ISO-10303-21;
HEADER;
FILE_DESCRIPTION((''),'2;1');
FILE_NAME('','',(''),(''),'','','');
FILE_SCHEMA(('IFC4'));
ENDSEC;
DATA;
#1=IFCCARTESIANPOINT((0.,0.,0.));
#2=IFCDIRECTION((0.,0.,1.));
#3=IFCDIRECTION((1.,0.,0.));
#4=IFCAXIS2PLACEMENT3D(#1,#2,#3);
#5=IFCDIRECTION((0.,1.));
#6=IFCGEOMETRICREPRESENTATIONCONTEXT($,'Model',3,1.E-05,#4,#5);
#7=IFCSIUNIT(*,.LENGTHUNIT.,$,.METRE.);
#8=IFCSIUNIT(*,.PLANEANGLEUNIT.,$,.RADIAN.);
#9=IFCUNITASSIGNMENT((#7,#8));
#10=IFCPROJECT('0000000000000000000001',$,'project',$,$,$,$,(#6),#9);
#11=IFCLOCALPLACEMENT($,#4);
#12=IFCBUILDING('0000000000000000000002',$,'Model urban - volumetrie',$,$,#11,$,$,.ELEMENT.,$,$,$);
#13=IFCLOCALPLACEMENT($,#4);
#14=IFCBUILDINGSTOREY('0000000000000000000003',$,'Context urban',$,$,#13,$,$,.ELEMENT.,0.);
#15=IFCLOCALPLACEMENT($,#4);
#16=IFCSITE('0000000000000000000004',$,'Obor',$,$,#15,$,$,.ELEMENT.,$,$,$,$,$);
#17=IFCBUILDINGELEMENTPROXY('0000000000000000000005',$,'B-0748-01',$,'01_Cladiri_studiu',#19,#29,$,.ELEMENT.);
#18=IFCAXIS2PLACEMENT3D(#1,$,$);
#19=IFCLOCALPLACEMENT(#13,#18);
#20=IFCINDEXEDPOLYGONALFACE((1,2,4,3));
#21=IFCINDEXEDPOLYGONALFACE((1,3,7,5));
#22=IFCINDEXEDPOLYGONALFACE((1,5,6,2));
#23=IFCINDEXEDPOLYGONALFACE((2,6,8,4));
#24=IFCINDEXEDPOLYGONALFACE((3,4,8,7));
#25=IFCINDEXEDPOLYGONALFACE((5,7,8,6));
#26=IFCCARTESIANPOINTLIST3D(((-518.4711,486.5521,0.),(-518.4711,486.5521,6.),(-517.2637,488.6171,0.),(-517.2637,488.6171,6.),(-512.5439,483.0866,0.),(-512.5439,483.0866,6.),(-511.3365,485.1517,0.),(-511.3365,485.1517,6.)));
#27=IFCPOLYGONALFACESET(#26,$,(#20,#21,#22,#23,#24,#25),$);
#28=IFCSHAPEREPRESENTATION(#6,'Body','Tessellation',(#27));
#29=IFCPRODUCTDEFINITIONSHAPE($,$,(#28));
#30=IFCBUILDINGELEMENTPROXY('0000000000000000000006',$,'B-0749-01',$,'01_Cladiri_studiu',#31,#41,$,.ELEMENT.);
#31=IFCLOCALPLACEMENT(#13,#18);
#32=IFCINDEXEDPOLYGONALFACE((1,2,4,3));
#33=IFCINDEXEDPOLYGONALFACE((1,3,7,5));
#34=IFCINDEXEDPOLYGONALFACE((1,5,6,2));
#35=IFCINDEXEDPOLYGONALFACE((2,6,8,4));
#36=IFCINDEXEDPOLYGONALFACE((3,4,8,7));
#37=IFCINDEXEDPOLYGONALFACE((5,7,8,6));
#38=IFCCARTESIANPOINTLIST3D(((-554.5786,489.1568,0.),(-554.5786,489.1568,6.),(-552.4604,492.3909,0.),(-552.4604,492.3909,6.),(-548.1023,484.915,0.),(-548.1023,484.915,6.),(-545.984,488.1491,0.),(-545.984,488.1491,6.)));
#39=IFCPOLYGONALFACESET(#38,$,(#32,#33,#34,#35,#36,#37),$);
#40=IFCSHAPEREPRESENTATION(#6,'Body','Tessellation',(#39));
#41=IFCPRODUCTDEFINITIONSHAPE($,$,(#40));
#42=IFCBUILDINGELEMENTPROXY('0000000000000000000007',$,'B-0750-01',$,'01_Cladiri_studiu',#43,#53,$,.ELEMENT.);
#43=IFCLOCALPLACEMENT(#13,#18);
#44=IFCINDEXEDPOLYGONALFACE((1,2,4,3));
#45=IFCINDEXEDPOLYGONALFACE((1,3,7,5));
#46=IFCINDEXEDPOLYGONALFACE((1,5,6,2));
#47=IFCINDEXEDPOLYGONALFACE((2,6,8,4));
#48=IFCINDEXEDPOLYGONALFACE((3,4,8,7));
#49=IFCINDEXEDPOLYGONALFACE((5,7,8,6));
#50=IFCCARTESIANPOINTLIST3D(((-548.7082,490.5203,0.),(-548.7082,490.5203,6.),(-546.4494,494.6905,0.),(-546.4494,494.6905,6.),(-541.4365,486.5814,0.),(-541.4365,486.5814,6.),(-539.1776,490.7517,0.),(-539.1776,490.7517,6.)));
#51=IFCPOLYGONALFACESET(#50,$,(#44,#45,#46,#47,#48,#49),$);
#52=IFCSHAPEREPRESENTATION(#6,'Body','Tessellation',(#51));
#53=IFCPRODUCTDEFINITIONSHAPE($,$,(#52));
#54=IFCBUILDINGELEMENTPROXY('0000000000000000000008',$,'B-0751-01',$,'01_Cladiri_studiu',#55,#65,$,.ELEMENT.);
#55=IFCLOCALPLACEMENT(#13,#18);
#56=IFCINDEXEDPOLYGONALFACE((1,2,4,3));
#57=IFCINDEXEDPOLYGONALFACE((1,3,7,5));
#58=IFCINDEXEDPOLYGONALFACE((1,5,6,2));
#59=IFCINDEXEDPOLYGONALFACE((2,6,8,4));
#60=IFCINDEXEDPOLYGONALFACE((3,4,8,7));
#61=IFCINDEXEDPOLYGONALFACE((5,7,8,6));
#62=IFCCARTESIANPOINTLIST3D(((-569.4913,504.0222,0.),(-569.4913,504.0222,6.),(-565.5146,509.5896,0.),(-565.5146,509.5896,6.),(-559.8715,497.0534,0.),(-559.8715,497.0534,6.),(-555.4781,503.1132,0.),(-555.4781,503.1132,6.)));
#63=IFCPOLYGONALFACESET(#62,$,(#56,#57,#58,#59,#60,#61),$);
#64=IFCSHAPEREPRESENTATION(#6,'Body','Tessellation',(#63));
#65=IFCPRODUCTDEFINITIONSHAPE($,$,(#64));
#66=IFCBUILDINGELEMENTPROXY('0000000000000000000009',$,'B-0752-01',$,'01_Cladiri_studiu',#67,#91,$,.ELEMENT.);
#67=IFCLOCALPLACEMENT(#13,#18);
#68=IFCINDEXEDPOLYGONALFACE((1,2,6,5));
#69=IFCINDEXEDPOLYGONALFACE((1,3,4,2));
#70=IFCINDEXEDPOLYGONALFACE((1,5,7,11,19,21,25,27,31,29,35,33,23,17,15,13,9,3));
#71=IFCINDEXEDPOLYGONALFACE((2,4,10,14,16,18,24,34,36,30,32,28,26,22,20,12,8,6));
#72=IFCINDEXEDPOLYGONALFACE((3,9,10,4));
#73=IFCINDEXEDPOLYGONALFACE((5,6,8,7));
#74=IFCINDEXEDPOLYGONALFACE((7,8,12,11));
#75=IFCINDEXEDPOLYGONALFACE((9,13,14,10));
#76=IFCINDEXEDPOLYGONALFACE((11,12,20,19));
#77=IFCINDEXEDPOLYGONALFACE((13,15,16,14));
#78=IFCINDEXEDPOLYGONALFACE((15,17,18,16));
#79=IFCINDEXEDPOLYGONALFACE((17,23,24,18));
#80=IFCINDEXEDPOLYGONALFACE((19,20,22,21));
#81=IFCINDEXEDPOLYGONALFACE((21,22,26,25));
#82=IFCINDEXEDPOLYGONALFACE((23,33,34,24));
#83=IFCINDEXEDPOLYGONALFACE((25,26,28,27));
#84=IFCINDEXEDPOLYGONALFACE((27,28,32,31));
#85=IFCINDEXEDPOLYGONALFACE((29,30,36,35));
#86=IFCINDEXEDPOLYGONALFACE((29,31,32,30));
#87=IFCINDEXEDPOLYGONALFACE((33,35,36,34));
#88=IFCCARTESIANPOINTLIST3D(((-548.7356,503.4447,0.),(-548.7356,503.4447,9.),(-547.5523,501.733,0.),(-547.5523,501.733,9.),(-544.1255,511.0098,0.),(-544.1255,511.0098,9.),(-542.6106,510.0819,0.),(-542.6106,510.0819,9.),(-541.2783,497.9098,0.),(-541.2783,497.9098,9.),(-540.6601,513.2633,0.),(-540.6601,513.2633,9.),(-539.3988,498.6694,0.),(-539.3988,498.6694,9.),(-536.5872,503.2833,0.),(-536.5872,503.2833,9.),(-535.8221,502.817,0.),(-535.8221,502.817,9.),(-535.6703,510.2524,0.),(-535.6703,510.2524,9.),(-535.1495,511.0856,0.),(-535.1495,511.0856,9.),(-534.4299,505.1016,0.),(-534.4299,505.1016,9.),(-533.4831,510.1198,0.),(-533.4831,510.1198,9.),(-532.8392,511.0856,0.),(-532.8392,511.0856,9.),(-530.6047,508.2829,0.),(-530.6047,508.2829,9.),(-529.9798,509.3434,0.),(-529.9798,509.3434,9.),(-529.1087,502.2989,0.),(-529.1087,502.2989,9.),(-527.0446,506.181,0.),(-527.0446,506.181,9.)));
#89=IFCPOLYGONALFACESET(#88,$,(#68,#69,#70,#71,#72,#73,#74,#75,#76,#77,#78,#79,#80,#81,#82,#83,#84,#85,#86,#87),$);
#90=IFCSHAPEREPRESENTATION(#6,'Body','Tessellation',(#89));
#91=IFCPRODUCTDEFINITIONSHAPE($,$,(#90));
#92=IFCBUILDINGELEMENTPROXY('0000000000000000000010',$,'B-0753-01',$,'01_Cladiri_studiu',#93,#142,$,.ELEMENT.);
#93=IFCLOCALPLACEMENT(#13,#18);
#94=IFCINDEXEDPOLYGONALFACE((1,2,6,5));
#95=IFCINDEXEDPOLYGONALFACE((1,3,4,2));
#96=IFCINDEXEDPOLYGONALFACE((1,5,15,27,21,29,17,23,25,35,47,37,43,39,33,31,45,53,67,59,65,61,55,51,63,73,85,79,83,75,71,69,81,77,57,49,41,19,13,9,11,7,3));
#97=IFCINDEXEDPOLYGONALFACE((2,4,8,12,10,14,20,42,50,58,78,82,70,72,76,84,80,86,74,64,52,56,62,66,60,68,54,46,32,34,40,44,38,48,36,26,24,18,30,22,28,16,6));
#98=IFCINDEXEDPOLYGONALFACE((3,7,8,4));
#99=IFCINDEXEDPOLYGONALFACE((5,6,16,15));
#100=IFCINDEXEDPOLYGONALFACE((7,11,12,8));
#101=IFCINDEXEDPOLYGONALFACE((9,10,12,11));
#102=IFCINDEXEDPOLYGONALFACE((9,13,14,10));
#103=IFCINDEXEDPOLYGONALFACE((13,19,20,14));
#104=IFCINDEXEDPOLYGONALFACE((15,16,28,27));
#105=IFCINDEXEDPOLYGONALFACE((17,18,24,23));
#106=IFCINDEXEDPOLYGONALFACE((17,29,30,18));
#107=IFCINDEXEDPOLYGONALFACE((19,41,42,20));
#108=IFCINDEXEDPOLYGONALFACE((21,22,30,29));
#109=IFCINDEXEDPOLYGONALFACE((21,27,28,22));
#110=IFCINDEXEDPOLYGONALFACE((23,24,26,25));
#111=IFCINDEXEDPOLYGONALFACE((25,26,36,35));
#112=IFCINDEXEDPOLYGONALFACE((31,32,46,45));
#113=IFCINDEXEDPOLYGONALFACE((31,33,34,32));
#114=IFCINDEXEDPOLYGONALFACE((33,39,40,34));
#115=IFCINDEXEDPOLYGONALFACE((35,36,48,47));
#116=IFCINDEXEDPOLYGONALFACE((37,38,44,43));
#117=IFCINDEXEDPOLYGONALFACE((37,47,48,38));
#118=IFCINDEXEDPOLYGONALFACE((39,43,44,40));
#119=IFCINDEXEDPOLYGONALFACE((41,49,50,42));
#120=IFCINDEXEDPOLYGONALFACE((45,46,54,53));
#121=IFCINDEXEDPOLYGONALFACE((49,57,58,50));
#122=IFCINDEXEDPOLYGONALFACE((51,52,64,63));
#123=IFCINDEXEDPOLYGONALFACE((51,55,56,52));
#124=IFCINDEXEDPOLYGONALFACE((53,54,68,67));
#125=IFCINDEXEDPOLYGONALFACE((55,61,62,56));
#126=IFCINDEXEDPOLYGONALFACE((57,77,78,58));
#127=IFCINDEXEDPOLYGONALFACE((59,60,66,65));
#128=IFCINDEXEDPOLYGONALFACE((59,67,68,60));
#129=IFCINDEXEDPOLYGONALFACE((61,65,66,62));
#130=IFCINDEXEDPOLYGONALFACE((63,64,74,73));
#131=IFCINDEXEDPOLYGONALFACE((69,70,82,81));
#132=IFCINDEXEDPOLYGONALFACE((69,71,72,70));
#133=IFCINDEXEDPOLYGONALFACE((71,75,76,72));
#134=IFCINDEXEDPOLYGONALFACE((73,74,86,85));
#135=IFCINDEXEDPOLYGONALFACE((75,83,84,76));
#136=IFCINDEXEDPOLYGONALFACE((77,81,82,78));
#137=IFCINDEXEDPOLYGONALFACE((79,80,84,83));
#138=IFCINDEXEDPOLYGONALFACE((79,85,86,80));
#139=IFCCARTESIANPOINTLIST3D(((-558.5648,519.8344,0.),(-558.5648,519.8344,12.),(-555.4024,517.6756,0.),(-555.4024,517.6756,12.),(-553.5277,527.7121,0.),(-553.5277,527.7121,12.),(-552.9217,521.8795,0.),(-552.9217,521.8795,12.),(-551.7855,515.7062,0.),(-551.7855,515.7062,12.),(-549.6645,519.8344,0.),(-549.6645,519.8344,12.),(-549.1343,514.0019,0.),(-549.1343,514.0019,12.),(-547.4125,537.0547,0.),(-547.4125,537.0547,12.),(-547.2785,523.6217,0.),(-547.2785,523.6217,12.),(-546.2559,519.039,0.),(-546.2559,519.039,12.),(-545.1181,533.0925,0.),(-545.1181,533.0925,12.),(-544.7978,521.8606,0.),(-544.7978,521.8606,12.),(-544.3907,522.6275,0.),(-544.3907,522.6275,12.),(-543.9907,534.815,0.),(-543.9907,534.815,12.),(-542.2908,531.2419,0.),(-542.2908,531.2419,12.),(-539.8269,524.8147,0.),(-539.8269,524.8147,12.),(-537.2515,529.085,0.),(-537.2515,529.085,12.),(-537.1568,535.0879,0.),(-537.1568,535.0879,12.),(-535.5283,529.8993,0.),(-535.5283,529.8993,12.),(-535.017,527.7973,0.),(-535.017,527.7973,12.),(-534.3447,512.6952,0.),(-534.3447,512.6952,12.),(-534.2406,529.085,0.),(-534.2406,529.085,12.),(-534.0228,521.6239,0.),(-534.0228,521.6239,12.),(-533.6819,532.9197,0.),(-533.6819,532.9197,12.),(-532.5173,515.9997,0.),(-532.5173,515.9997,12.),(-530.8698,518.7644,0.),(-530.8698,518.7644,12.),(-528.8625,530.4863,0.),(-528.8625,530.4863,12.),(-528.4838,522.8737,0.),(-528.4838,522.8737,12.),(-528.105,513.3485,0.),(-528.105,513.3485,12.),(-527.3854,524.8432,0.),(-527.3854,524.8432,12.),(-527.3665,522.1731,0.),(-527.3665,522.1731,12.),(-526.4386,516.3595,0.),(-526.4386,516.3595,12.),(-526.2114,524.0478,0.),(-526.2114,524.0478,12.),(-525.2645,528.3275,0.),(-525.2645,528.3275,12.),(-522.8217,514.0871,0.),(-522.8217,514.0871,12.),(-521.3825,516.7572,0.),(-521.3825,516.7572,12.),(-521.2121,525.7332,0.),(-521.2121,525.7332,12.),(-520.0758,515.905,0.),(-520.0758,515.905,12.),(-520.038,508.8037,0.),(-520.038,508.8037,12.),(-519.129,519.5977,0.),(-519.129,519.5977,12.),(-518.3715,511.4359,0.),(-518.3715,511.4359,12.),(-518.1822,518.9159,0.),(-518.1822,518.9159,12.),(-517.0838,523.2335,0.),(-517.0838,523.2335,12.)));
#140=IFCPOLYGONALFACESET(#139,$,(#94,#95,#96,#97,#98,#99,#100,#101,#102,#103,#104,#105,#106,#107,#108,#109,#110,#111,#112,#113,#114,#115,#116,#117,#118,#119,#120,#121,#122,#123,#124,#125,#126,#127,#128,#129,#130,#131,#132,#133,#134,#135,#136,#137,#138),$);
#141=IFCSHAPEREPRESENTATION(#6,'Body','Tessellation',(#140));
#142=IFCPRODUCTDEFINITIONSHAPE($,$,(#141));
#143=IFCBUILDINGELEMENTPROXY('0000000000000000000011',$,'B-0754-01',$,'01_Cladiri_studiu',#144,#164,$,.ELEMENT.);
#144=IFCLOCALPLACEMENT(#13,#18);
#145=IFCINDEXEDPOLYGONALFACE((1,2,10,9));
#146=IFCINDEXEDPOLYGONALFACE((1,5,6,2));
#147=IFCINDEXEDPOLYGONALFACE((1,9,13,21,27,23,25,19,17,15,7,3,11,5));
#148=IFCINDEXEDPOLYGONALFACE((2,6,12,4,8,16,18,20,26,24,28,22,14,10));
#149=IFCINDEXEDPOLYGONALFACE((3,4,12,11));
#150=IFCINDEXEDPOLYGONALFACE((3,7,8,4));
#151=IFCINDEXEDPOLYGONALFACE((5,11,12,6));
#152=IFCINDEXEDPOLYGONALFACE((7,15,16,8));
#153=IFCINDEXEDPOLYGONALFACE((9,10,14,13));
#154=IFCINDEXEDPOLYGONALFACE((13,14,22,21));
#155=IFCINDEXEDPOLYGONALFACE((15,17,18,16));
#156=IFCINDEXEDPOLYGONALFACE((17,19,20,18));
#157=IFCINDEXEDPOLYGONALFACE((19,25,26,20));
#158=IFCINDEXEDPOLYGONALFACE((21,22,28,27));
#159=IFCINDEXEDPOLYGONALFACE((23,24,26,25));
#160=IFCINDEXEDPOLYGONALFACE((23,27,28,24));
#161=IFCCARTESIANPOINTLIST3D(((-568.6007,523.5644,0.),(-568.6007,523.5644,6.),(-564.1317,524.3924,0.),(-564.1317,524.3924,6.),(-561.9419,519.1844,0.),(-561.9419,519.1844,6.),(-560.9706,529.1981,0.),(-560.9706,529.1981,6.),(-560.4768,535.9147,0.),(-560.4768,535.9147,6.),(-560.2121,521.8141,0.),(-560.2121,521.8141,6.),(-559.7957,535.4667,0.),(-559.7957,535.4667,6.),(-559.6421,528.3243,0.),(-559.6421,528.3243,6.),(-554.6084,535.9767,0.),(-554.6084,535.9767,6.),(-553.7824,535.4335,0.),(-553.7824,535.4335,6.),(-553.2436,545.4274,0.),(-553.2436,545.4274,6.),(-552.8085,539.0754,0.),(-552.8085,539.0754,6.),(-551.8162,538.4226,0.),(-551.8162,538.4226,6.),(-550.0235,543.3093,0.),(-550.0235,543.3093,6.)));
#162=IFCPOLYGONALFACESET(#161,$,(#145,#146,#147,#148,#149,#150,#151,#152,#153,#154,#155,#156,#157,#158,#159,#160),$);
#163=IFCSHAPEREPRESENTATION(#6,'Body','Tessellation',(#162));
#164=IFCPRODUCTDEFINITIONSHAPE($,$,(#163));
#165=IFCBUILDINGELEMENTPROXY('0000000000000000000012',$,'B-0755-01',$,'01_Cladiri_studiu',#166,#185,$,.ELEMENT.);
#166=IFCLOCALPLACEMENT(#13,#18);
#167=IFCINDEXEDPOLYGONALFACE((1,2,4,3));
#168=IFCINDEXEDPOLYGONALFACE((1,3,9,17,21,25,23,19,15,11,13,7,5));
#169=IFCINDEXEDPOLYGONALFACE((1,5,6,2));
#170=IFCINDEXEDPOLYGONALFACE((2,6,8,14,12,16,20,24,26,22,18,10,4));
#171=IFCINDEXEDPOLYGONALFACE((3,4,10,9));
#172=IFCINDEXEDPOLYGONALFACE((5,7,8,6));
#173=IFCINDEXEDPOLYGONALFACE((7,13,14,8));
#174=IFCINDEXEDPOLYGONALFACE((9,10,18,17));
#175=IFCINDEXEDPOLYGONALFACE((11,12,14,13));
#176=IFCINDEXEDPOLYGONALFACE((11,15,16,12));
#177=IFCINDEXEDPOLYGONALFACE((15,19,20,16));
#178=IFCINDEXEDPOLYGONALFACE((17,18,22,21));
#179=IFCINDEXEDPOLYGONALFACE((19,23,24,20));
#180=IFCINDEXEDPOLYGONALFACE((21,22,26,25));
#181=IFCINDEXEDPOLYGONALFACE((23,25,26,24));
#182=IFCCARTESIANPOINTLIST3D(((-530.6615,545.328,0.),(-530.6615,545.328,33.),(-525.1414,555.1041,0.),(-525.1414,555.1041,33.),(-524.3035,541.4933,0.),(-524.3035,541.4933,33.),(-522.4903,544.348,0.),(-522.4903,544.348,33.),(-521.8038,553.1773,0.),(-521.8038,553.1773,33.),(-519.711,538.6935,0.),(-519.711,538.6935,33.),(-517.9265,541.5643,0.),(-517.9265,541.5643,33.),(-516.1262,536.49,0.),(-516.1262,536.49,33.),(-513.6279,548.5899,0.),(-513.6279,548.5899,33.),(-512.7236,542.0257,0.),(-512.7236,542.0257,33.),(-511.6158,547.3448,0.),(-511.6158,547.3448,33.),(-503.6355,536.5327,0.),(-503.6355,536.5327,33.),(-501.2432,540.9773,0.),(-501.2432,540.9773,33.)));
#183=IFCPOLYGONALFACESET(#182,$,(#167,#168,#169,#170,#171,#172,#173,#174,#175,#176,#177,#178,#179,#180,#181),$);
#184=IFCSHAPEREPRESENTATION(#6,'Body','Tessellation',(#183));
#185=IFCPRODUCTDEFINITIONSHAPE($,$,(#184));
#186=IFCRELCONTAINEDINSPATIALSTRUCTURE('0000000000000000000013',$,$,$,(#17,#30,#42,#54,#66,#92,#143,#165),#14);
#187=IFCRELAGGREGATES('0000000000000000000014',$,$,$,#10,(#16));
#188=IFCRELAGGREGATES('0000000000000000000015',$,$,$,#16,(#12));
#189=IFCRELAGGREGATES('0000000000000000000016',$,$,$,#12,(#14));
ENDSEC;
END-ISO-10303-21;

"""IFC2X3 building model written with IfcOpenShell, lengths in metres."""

from ifc_helpers import new_model, si_unit, direction, origin_with_axes, place, context, project, spatial, polyline, outline, extrude, element, save


model = new_model("IFC2X3")

# Units and contexts
model_context = context("Model", 3, precision=1e-05, world=origin_with_axes(), true_north=direction((0.0, 1.0)))
ifc_project = project(units=[si_unit("LENGTHUNIT", "METRE"), si_unit("PLANEANGLEUNIT", "RADIAN")], contexts=[model_context])

# Site, building, storey
site_placement = place(None, origin_with_axes())
site = spatial("IfcSite", under=ifc_project, at=site_placement, Name="Obor", CompositionType="ELEMENT")
building_placement = place(None, origin_with_axes())
building = spatial("IfcBuilding", under=site, at=building_placement, Name="Model urban - volumetrie", CompositionType="ELEMENT")
storey_placement = place(None, origin_with_axes())
storey = spatial("IfcBuildingStorey", under=building, at=storey_placement, Name="Context urban", CompositionType="ELEMENT", Elevation=0.0)

# Building element proxies
proxy_1_placement = place(None, origin_with_axes())
element("IfcBuildingElementProxy", 1, at=proxy_1_placement, inside=storey, Name="B-0748-01", ObjectType="01_Cladiri_studiu", CompositionType="ELEMENT", context=model_context, shape_type="SweptSolid", body=[
    extrude(outline(polyline([(-518.4711, 486.5521), (-512.5439, 483.0866), (-511.3365, 485.1517), (-517.2637, 488.6171), (-518.4711, 486.5521)])), origin_with_axes(), (0.0, 0.0, 1.0), 6.0),
])
proxy_2_placement = place(None, origin_with_axes())
element("IfcBuildingElementProxy", 2, at=proxy_2_placement, inside=storey, Name="B-0749-01", ObjectType="01_Cladiri_studiu", CompositionType="ELEMENT", context=model_context, shape_type="SweptSolid", body=[
    extrude(outline(polyline([(-545.984, 488.1491), (-552.4604, 492.3909), (-554.5786, 489.1568), (-548.1023, 484.915), (-545.984, 488.1491)])), origin_with_axes(), (0.0, 0.0, 1.0), 6.0),
])
proxy_3_placement = place(None, origin_with_axes())
element("IfcBuildingElementProxy", 3, at=proxy_3_placement, inside=storey, Name="B-0750-01", ObjectType="01_Cladiri_studiu", CompositionType="ELEMENT", context=model_context, shape_type="SweptSolid", body=[
    extrude(outline(polyline([(-539.1776, 490.7517), (-546.4494, 494.6905), (-548.7082, 490.5203), (-541.4365, 486.5814), (-539.1776, 490.7517)])), origin_with_axes(), (0.0, 0.0, 1.0), 6.0),
])
proxy_4_placement = place(None, origin_with_axes())
element("IfcBuildingElementProxy", 4, at=proxy_4_placement, inside=storey, Name="B-0751-01", ObjectType="01_Cladiri_studiu", CompositionType="ELEMENT", context=model_context, shape_type="SweptSolid", body=[
    extrude(outline(polyline([(-559.8715, 497.0534), (-555.4781, 503.1132), (-565.5146, 509.5896), (-569.4913, 504.0222), (-559.8715, 497.0534)])), origin_with_axes(), (0.0, 0.0, 1.0), 6.0),
])
proxy_5_placement = place(None, origin_with_axes())
element("IfcBuildingElementProxy", 5, at=proxy_5_placement, inside=storey, Name="B-0752-01", ObjectType="01_Cladiri_studiu", CompositionType="ELEMENT", context=model_context, shape_type="SweptSolid", body=[
    extrude(outline(polyline([(-539.3988, 498.6694), (-536.5872, 503.2833), (-535.8221, 502.817), (-534.4299, 505.1016), (-529.1087, 502.2989), (-527.0446, 506.181), (-530.6047, 508.2829), (-529.9798, 509.3434), (-532.8392, 511.0856), (-533.4831, 510.1198), (-535.1495, 511.0856), (-535.6703, 510.2524), (-540.6601, 513.2633), (-542.6106, 510.0819), (-544.1255, 511.0098), (-548.7356, 503.4447), (-547.5523, 501.733), (-541.2783, 497.9098), (-539.3988, 498.6694)])), origin_with_axes(), (0.0, 0.0, 1.0), 9.0),
])
proxy_6_placement = place(None, origin_with_axes())
element("IfcBuildingElementProxy", 6, at=proxy_6_placement, inside=storey, Name="B-0753-01", ObjectType="01_Cladiri_studiu", CompositionType="ELEMENT", context=model_context, shape_type="SweptSolid", body=[
    extrude(outline(polyline([(-532.5173, 515.9997), (-528.105, 513.3485), (-520.038, 508.8037), (-518.3715, 511.4359), (-522.8217, 514.0871), (-521.3825, 516.7572), (-520.0758, 515.905), (-518.1822, 518.9159), (-519.129, 519.5977), (-517.0838, 523.2335), (-521.2121, 525.7332), (-526.4386, 516.3595), (-530.8698, 518.7644), (-528.4838, 522.8737), (-527.3665, 522.1731), (-526.2114, 524.0478), (-527.3854, 524.8432), (-525.2645, 528.3275), (-528.8625, 530.4863), (-534.0228, 521.6239), (-539.8269, 524.8147), (-537.2515, 529.085), (-535.017, 527.7973), (-534.2406, 529.085), (-535.5283, 529.8993), (-533.6819, 532.9197), (-537.1568, 535.0879), (-544.3907, 522.6275), (-544.7978, 521.8606), (-547.2785, 523.6217), (-542.2908, 531.2419), (-545.1181, 533.0925), (-543.9907, 534.815), (-547.4125, 537.0547), (-553.5277, 527.7121), (-558.5648, 519.8344), (-555.4024, 517.6756), (-552.9217, 521.8795), (-549.6645, 519.8344), (-551.7855, 515.7062), (-549.1343, 514.0019), (-546.2559, 519.039), (-534.3447, 512.6952), (-532.5173, 515.9997), (-536.0964, 518.0638), (-532.5173, 515.9997)])), origin_with_axes(), (0.0, 0.0, 1.0), 12.0),
])
proxy_7_placement = place(None, origin_with_axes())
element("IfcBuildingElementProxy", 7, at=proxy_7_placement, inside=storey, Name="B-0754-01", ObjectType="01_Cladiri_studiu", CompositionType="ELEMENT", context=model_context, shape_type="SweptSolid", body=[
    extrude(outline(polyline([(-559.6421, 528.3243), (-554.6084, 535.9767), (-553.7824, 535.4335), (-551.8162, 538.4226), (-552.8085, 539.0754), (-550.0235, 543.3093), (-553.2436, 545.4274), (-559.7957, 535.4667), (-560.4768, 535.9147), (-568.6007, 523.5644), (-561.9419, 519.1844), (-560.2121, 521.8141), (-564.1317, 524.3924), (-560.9706, 529.1981), (-559.6421, 528.3243)])), origin_with_axes(), (0.0, 0.0, 1.0), 6.0),
])
proxy_8_placement = place(None, origin_with_axes())
element("IfcBuildingElementProxy", 8, at=proxy_8_placement, inside=storey, Name="B-0755-01", ObjectType="01_Cladiri_studiu", CompositionType="ELEMENT", context=model_context, shape_type="SweptSolid", body=[
    extrude(outline(polyline([(-511.6158, 547.3448), (-513.6279, 548.5899), (-521.8038, 553.1773), (-525.1414, 555.1041), (-530.6615, 545.328), (-524.3035, 541.4933), (-522.4903, 544.348), (-517.9265, 541.5643), (-519.711, 538.6935), (-516.1262, 536.49), (-512.7236, 542.0257), (-503.6355, 536.5327), (-501.2432, 540.9773), (-511.6158, 547.3448)])), origin_with_axes(), (0.0, 0.0, 1.0), 33.0),
])

save(model, "model.ifc")
